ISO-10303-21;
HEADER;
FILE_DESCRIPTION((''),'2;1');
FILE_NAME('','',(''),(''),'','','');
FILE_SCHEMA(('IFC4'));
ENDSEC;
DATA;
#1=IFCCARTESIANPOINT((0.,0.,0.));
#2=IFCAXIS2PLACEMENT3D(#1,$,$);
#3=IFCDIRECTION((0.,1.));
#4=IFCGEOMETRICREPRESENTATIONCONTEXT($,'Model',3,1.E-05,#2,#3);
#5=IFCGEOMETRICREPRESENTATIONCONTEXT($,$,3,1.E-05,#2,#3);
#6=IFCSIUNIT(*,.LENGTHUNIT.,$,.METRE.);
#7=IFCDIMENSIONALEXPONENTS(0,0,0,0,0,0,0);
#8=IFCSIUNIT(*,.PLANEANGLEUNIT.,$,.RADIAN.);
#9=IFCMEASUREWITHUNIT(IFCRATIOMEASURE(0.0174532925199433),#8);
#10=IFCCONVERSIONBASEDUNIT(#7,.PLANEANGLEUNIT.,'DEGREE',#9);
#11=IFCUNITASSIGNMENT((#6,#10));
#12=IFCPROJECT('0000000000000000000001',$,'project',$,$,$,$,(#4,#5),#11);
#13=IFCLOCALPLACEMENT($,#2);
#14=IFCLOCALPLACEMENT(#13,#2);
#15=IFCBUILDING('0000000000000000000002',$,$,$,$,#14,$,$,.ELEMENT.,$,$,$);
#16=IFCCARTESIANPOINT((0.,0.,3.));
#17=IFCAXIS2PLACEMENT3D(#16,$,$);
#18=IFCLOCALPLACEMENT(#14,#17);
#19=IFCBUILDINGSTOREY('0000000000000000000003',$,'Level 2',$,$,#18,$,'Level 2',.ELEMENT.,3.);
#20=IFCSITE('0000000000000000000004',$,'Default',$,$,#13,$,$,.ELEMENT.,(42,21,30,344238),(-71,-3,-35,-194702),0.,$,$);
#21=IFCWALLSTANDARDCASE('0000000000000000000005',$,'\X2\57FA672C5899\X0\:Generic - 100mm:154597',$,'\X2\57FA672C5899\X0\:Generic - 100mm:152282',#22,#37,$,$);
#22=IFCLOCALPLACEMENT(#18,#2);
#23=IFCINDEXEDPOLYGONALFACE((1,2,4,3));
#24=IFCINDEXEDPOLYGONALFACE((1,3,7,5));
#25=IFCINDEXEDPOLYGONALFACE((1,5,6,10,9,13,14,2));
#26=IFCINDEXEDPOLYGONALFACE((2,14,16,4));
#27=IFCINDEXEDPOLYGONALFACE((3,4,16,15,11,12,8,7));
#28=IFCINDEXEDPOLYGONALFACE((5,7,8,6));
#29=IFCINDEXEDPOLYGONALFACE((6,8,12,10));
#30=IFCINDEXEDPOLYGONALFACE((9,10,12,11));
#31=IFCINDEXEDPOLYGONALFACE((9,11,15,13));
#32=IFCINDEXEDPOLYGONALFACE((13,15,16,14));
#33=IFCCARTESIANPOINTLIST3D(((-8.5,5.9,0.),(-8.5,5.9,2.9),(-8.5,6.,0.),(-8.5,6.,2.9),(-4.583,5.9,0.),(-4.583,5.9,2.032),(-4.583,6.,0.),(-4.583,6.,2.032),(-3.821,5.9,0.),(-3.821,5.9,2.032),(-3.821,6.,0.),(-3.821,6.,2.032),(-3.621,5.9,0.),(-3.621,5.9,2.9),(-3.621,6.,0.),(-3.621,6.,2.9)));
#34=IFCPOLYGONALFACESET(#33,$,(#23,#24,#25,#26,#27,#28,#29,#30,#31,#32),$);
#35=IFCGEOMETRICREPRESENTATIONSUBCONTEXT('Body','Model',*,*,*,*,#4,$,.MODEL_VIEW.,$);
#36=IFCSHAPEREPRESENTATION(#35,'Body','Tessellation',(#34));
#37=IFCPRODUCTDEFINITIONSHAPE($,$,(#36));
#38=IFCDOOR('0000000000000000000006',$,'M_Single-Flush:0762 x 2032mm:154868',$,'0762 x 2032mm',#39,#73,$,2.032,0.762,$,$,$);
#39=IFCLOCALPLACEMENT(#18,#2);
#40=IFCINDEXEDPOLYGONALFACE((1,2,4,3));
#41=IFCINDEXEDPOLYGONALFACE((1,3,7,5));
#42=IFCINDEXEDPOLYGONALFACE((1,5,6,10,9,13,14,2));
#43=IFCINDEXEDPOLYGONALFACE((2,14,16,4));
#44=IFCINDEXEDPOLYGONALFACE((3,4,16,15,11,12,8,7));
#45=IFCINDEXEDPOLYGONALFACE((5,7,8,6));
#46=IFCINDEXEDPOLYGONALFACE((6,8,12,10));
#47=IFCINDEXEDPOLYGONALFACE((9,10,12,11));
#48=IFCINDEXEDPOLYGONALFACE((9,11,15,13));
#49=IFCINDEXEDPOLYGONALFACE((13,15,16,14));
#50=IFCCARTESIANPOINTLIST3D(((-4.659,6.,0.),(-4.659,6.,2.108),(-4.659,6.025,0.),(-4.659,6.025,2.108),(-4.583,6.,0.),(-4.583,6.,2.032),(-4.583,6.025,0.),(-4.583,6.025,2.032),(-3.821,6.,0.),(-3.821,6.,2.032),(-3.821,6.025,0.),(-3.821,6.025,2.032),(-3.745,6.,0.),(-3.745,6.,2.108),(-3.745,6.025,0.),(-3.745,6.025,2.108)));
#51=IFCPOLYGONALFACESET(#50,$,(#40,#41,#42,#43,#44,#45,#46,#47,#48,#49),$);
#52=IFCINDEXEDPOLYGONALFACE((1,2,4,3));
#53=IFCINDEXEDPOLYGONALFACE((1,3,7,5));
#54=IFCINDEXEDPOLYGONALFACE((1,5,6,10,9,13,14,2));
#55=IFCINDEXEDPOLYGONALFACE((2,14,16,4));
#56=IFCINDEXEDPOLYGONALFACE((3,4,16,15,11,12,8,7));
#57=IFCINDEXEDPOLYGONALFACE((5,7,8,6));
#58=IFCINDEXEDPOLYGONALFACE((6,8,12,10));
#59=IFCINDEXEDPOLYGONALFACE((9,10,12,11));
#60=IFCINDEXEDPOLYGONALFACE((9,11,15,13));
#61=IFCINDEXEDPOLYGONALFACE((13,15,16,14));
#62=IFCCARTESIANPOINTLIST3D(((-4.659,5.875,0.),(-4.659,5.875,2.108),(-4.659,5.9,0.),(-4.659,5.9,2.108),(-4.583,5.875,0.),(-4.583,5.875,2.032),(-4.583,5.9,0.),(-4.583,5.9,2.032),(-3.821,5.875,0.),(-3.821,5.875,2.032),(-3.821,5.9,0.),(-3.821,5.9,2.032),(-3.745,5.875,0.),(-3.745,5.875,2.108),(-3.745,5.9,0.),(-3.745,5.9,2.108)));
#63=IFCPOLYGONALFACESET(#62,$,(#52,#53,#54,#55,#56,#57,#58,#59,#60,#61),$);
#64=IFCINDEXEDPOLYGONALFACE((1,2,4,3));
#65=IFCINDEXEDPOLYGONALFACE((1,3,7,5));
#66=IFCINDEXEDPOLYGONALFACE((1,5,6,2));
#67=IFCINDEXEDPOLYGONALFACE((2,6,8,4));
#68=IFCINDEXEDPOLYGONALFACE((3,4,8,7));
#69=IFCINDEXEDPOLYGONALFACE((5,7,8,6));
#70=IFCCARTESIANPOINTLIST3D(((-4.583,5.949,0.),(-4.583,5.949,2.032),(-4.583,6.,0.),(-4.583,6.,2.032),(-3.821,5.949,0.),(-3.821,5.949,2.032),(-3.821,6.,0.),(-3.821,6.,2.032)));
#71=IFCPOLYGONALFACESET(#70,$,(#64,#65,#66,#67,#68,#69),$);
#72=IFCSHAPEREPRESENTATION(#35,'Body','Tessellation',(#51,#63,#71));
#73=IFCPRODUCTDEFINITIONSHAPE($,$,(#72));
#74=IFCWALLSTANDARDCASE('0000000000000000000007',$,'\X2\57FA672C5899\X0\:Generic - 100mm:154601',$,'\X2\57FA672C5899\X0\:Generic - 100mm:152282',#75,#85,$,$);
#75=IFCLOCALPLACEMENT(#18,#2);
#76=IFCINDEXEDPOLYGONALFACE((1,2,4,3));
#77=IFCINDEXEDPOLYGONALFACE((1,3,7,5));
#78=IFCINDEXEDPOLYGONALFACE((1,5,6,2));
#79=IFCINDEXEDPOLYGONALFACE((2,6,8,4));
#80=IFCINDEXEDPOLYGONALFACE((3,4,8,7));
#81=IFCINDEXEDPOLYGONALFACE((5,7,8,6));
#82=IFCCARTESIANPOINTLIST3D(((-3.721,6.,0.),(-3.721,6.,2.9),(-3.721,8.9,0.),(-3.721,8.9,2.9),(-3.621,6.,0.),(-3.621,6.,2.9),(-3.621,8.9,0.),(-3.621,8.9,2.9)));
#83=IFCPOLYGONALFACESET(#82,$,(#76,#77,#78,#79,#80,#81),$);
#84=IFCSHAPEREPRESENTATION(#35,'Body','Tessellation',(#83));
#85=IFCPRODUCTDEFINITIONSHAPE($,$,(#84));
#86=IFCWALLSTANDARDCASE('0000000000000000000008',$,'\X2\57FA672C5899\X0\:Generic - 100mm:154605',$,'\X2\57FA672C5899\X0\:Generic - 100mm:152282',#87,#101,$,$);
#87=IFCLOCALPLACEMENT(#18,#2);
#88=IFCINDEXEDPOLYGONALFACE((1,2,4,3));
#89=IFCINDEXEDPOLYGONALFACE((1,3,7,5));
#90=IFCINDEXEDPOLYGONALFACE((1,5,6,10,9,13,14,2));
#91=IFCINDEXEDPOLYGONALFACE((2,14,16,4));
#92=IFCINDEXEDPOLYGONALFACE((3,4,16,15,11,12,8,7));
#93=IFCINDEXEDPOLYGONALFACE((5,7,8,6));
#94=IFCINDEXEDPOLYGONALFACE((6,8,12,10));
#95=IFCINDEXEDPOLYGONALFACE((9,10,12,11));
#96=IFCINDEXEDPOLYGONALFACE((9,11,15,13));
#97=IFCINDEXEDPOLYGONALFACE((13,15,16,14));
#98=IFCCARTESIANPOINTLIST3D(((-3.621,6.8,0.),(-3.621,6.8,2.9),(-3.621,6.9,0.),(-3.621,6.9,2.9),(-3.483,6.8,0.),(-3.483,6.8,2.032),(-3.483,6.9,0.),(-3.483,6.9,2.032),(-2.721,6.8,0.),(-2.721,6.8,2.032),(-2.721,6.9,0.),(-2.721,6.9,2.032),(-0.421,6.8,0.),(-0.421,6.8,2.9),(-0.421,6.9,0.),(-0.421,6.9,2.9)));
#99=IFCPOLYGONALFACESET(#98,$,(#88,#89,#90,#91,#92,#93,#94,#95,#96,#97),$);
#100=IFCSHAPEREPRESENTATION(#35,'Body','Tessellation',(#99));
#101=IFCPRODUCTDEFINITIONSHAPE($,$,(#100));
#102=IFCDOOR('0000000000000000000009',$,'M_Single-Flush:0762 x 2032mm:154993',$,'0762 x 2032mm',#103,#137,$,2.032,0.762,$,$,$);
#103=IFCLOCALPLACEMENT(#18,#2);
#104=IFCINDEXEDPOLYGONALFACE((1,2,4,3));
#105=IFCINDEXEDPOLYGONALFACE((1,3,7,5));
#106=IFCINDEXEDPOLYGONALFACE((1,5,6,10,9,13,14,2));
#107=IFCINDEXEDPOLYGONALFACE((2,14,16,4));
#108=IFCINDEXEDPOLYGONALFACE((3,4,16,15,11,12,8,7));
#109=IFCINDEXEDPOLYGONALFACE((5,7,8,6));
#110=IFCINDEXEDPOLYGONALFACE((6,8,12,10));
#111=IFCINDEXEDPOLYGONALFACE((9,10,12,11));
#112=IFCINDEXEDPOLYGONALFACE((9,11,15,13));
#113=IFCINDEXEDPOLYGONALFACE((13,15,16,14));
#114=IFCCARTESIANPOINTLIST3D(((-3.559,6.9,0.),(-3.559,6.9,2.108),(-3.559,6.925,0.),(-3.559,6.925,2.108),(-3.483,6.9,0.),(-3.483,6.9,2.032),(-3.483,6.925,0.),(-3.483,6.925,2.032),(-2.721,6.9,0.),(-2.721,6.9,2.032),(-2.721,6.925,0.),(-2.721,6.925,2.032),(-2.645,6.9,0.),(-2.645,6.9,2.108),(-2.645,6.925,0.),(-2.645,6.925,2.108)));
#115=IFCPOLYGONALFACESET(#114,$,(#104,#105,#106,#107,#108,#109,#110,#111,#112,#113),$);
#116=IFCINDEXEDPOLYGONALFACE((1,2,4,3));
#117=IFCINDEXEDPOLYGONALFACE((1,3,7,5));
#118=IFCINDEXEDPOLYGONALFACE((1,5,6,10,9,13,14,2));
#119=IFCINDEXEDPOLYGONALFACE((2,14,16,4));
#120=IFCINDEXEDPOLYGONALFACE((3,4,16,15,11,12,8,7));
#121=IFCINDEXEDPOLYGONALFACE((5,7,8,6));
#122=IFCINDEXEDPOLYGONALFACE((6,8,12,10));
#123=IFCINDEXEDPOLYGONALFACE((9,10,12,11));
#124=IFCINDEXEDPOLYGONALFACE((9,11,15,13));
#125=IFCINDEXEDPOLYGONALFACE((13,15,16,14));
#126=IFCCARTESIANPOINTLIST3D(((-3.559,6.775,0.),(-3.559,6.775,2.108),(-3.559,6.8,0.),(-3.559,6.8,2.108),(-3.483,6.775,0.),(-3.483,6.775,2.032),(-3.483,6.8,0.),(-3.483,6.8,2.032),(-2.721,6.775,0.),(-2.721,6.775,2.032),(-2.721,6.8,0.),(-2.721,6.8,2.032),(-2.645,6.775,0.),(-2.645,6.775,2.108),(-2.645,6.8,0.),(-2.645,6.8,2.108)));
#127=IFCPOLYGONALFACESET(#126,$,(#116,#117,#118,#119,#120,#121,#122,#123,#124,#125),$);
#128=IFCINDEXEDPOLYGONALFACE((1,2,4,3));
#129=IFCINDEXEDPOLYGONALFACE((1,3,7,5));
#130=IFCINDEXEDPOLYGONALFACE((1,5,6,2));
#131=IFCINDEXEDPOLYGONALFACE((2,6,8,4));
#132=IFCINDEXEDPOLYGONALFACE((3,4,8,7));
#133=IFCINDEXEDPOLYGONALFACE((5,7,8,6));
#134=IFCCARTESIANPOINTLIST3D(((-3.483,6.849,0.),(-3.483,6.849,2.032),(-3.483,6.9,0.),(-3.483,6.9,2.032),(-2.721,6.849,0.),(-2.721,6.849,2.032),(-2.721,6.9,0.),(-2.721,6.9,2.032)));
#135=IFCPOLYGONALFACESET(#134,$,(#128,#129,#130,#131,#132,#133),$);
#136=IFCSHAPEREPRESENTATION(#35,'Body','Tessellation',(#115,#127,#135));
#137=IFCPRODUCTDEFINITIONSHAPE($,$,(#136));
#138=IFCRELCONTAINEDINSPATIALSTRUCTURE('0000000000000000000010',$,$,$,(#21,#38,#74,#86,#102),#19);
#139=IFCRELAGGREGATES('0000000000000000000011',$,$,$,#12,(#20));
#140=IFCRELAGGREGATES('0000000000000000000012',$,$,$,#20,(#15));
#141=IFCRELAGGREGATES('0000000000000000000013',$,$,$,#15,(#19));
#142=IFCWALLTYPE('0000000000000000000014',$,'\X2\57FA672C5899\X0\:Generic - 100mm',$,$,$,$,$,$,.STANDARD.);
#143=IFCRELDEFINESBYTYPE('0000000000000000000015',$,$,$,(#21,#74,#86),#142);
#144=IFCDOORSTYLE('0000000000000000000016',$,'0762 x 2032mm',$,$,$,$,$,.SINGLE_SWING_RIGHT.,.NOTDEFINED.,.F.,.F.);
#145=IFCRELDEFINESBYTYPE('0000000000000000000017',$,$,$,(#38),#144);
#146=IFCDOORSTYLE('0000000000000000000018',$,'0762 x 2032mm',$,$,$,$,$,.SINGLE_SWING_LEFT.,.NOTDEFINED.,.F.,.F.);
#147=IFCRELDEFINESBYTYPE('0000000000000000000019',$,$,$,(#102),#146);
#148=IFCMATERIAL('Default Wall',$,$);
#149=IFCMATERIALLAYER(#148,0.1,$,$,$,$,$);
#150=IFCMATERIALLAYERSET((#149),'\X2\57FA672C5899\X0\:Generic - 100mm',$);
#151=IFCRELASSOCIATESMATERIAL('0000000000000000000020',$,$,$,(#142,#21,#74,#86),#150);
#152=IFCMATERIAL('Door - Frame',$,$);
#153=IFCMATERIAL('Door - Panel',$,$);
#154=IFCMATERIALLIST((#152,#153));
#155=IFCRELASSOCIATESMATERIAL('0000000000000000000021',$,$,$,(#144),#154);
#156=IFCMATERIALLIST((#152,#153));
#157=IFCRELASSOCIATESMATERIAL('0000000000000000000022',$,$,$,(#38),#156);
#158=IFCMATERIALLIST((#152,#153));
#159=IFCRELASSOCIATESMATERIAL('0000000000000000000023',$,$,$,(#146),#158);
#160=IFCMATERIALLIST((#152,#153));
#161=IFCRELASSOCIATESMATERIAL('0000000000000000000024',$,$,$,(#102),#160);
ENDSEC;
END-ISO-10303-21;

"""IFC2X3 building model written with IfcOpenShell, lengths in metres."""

from ifc_helpers import new_model, entity, si_unit, converted_unit, direction, frame, frame_2d, origin, origin_2d_with_axis, place, context, subcontext, project, spatial, polyline, rectangle, outline, extrude, clip, bounded_halfspace, source, transform, mapped, material, material_list, layer, layer_set, layer_usage, type_object, type_shapes, element, fill, save


model = new_model("IFC2X3")

# Units and contexts
model_context = context("Model", 3, precision=1e-05, world=origin(), true_north=direction((0.0, 1.0)))
context_of_model = context(None, 3, precision=1e-05, world=origin(), true_north=direction((0.0, 1.0)))
body_context = subcontext(model_context, "Body", "Model", "MODEL_VIEW")
ifc_project = project(units=[si_unit("LENGTHUNIT", "METRE"), converted_unit("PLANEANGLEUNIT", "DEGREE", entity("IfcRatioMeasure", 0.0174532925199433), si_unit("PLANEANGLEUNIT", "RADIAN"), dimensions=[0, 0, 0, 0, 0, 0, 0])], contexts=[model_context, context_of_model])

# Site, building, storey
site_placement = place(None, origin())
site = spatial("IfcSite", under=ifc_project, at=site_placement, Name="Default", CompositionType="ELEMENT", RefLatitude=(42, 21, 30, 344238), RefLongitude=(-71, -3, -35, -194702), RefElevation=0.0)
building_placement = place(site_placement, origin())
building = spatial("IfcBuilding", under=site, at=building_placement, CompositionType="ELEMENT")
storey_placement = place(building_placement, frame((0.0, 0.0, 3.0)))
storey = spatial("IfcBuildingStorey", under=building, at=storey_placement, Name="Level 2", LongName="Level 2", CompositionType="ELEMENT", Elevation=3.0)

# Shared definitions
ifc_material_1 = material(Name="Default Wall")

# Wall, opening, door
ifc_layer_1 = layer(ifc_material_1, 0.1)
ifc_layer_set_1 = layer_set([ifc_layer_1], Name="基本墙:Generic - 100mm")
wall_type_1 = type_object("IfcWallType", Name="基本墙:Generic - 100mm", PredefinedType="STANDARD", material=ifc_layer_set_1)
ifc_material_2 = material(Name="Door - Panel")
ifc_material_3 = material(Name="Door - Frame")
ifc_layer_usage_1 = layer_usage(ifc_layer_set_1, "AXIS2", "NEGATIVE", 0.05)
wall_1_placement = place(storey_placement, frame((-3.621, 5.95, 0.0), z_axis=(0.0, 0.0, 1.0), x_axis=(-1.0, 0.0, 0.0)))
wall_1 = element("IfcWallStandardCase", 1, at=wall_1_placement, inside=storey, type_object=wall_type_1, material=ifc_layer_usage_1, Name="基本墙:Generic - 100mm:154597", ObjectType="基本墙:Generic - 100mm:152282", context=body_context, shape_type="Clipping", body=[
    clip(extrude(rectangle(XDim=4.879, YDim=0.1, at=frame_2d((2.4395, 0.0), x_axis=(-1.0, 0.0))), origin(), (0.0, 0.0, 1.0), 3.2), bounded_halfspace(frame((0.0, -0.05, 2.9), z_axis=(0.0, 0.0, -1.0), x_axis=(0.0, 1.0, 0.0)), True, frame((0.0, -0.05, 2.9), z_axis=(0.0, 0.0, -1.0), x_axis=(0.0, 1.0, 0.0)), polyline([(0.0, 0.0), (0.1, 0.0), (0.1, 4.879), (0.0, 4.879), (0.0, 0.1), (0.0, 0.0)]))),
])
opening_1_placement = place(wall_1_placement, frame((0.962, 0.05, 0.0)))
opening_1 = element("IfcOpeningElement", 2, at=opening_1_placement, cuts=wall_1, ObjectType="Opening", context=body_context, shape_type="SweptSolid", body=[
    extrude(rectangle(XDim=0.762, YDim=2.032, at=frame_2d((1.016, 0.381), x_axis=(0.0, 1.0))), frame((0.0, 0.0, 0.0), z_axis=(0.0, -1.0, 0.0), x_axis=(0.0, 0.0, 1.0)), (0.0, 0.0, 1.0), 0.1),
])
ifc_material_list_1 = material_list([ifc_material_3, ifc_material_2])
ifc_material_list_2 = material_list([ifc_material_3, ifc_material_2])
door_style_1 = type_object("IfcDoorStyle", Name="0762 x 2032mm", ConstructionType="NOTDEFINED", OperationType="SINGLE_SWING_RIGHT", ParameterTakesPrecedence=False, Sizeable=False, material=ifc_material_list_2)
shared_shape_1 = source(origin(), body_context, "Body", "SweptSolid", [
    extrude(outline(polyline([(-0.457, -1.073), (0.457, -1.073), (0.457, 1.035), (0.381, 1.035), (0.381, -0.997), (-0.381, -0.997), (-0.381, 1.035), (-0.457, 1.035), (-0.457, -1.073)])), frame((0.381, 0.1, 1.035), z_axis=(0.0, 1.0, 0.0), x_axis=(1.0, 0.0, 0.0)), (0.0, 0.0, 1.0), 0.025),
    extrude(outline(polyline([(-1.073, -0.457), (1.035, -0.457), (1.035, -0.381), (-0.997, -0.381), (-0.997, 0.381), (1.035, 0.381), (1.035, 0.457), (-1.073, 0.457), (-1.073, -0.457)])), frame((0.381, -0.025, 1.035), z_axis=(0.0, 1.0, 0.0), x_axis=(0.0, 0.0, -1.0)), (0.0, 0.0, 1.0), 0.025),
    extrude(rectangle(XDim=0.051, YDim=0.762, at=origin_2d_with_axis()), frame((0.381, 0.0745, 0.0), z_axis=(0.0, 0.0, 1.0), x_axis=(0.0, 1.0, 0.0)), (0.0, 0.0, 1.0), 2.032),
])
type_shapes(door_style_1, [shared_shape_1])
door_1_placement = place(opening_1_placement, frame((0.0, 0.0, 0.0), z_axis=(0.0, 0.0, 1.0), x_axis=(-1.0, 0.0, 0.0)))
door_1 = element("IfcDoor", 3, at=door_1_placement, inside=storey, type_object=door_style_1, material=ifc_material_list_1, Name="M_Single-Flush:0762 x 2032mm:154868", ObjectType="0762 x 2032mm", OverallHeight=2.032, OverallWidth=0.762, context=body_context, shape_type="MappedRepresentation", body=[
    mapped(shared_shape_1, transform((0.0, 0.0, 0.0), scale=1.0)),
])
fill(opening_1, door_1)

# Wall
ifc_layer_usage_2 = layer_usage(ifc_layer_set_1, "AXIS2", "NEGATIVE", 0.05)
wall_2_placement = place(storey_placement, frame((-3.671, 8.9, 0.0), z_axis=(0.0, 0.0, 1.0), x_axis=(0.0, -1.0, 0.0)))
element("IfcWallStandardCase", 4, at=wall_2_placement, inside=storey, type_object=wall_type_1, material=ifc_layer_usage_2, Name="基本墙:Generic - 100mm:154601", ObjectType="基本墙:Generic - 100mm:152282", context=body_context, shape_type="Clipping", body=[
    clip(extrude(rectangle(XDim=2.9, YDim=0.1, at=frame_2d((1.45, 0.0), x_axis=(-1.0, 0.0))), origin(), (0.0, 0.0, 1.0), 3.2), bounded_halfspace(frame((0.0, -0.05, 2.9), z_axis=(0.0, 0.0, -1.0), x_axis=(1.0, 0.0, 0.0)), True, frame((0.0, -0.05, 2.9), z_axis=(0.0, 0.0, -1.0), x_axis=(1.0, 0.0, 0.0)), polyline([(0.0, 0.0), (0.0, -0.1), (2.9, -0.1), (2.9, 0.0), (0.0, 0.0)]))),
])

# Wall, openings, door
ifc_layer_usage_3 = layer_usage(ifc_layer_set_1, "AXIS2", "NEGATIVE", 0.05)
wall_3_placement = place(storey_placement, frame((-3.621, 6.85, 0.0)))
wall_3 = element("IfcWallStandardCase", 5, at=wall_3_placement, inside=storey, type_object=wall_type_1, material=ifc_layer_usage_3, Name="基本墙:Generic - 100mm:154605", ObjectType="基本墙:Generic - 100mm:152282", context=body_context, shape_type="Clipping", body=[
    clip(extrude(rectangle(XDim=3.2, YDim=0.1, at=frame_2d((1.6, 0.0), x_axis=(-1.0, 0.0))), origin(), (0.0, 0.0, 1.0), 3.2), bounded_halfspace(frame((0.0, -0.05, 2.9), z_axis=(0.0, 0.0, -1.0), x_axis=(0.0, -1.0, 0.0)), True, frame((0.0, -0.05, 2.9), z_axis=(0.0, 0.0, -1.0), x_axis=(0.0, -1.0, 0.0)), polyline([(0.0, 0.0), (-0.1, 0.0), (-0.1, -3.2), (0.0, -3.2), (0.0, -1.2), (0.0, -1.1), (0.0, 0.0)]))),
])
opening_2_placement = place(wall_3_placement, frame((1.1, -0.812, 0.0)))
element("IfcOpeningElement", 6, at=opening_2_placement, cuts=wall_3, ObjectType="Opening", context=body_context, shape_type="SweptSolid", body=[
    extrude(rectangle(XDim=2.032, YDim=0.1, at=frame_2d((0.0, 0.0), x_axis=(0.0, 1.0))), frame((0.05, 0.0, 1.016), z_axis=(0.0, 1.0, 0.0), x_axis=(-1.0, 0.0, 0.0)), (0.0, 0.0, 1.0), 0.762),
])
opening_3_placement = place(wall_3_placement, frame((0.138, -0.05, 0.0)))
opening_3 = element("IfcOpeningElement", 7, at=opening_3_placement, cuts=wall_3, ObjectType="Opening", context=body_context, shape_type="SweptSolid", body=[
    extrude(rectangle(XDim=0.762, YDim=2.032, at=frame_2d((1.016, 0.381), x_axis=(0.0, -1.0))), frame((0.0, 0.0, 0.0), z_axis=(0.0, 1.0, 0.0), x_axis=(0.0, 0.0, 1.0)), (0.0, 0.0, 1.0), 0.1),
])
ifc_material_list_3 = material_list([ifc_material_3, ifc_material_2])
ifc_material_list_4 = material_list([ifc_material_3, ifc_material_2])
door_style_2 = type_object("IfcDoorStyle", Name="0762 x 2032mm", ConstructionType="NOTDEFINED", OperationType="SINGLE_SWING_LEFT", ParameterTakesPrecedence=False, Sizeable=False, material=ifc_material_list_4)
shared_shape_2 = source(origin(), body_context, "Body", "SweptSolid", [
    extrude(outline(polyline([(-0.457, -1.073), (0.457, -1.073), (0.457, 1.035), (0.381, 1.035), (0.381, -0.997), (-0.381, -0.997), (-0.381, 1.035), (-0.457, 1.035), (-0.457, -1.073)])), frame((0.381, 0.125, 1.035), z_axis=(0.0, -1.0, 0.0), x_axis=(-1.0, 0.0, 0.0)), (0.0, 0.0, 1.0), 0.025),
    extrude(outline(polyline([(-1.073, -0.457), (1.035, -0.457), (1.035, -0.381), (-0.997, -0.381), (-0.997, 0.381), (1.035, 0.381), (1.035, 0.457), (-1.073, 0.457), (-1.073, -0.457)])), frame((0.381, 0.0, 1.035), z_axis=(0.0, -1.0, 0.0), x_axis=(0.0, 0.0, -1.0)), (0.0, 0.0, 1.0), 0.025),
    extrude(rectangle(XDim=0.762, YDim=0.051, at=origin_2d_with_axis()), frame((0.381, 0.0745, 0.0)), (0.0, 0.0, 1.0), 2.032),
])
type_shapes(door_style_2, [shared_shape_2])
door_2_placement = place(opening_3_placement, origin())
door_2 = element("IfcDoor", 8, at=door_2_placement, inside=storey, type_object=door_style_2, material=ifc_material_list_3, Name="M_Single-Flush:0762 x 2032mm:154993", ObjectType="0762 x 2032mm", OverallHeight=2.032, OverallWidth=0.762, context=body_context, shape_type="MappedRepresentation", body=[
    mapped(shared_shape_2, transform((0.0, 0.0, 0.0), scale=1.0)),
])
fill(opening_3, door_2)

save(model, "model.ifc")
